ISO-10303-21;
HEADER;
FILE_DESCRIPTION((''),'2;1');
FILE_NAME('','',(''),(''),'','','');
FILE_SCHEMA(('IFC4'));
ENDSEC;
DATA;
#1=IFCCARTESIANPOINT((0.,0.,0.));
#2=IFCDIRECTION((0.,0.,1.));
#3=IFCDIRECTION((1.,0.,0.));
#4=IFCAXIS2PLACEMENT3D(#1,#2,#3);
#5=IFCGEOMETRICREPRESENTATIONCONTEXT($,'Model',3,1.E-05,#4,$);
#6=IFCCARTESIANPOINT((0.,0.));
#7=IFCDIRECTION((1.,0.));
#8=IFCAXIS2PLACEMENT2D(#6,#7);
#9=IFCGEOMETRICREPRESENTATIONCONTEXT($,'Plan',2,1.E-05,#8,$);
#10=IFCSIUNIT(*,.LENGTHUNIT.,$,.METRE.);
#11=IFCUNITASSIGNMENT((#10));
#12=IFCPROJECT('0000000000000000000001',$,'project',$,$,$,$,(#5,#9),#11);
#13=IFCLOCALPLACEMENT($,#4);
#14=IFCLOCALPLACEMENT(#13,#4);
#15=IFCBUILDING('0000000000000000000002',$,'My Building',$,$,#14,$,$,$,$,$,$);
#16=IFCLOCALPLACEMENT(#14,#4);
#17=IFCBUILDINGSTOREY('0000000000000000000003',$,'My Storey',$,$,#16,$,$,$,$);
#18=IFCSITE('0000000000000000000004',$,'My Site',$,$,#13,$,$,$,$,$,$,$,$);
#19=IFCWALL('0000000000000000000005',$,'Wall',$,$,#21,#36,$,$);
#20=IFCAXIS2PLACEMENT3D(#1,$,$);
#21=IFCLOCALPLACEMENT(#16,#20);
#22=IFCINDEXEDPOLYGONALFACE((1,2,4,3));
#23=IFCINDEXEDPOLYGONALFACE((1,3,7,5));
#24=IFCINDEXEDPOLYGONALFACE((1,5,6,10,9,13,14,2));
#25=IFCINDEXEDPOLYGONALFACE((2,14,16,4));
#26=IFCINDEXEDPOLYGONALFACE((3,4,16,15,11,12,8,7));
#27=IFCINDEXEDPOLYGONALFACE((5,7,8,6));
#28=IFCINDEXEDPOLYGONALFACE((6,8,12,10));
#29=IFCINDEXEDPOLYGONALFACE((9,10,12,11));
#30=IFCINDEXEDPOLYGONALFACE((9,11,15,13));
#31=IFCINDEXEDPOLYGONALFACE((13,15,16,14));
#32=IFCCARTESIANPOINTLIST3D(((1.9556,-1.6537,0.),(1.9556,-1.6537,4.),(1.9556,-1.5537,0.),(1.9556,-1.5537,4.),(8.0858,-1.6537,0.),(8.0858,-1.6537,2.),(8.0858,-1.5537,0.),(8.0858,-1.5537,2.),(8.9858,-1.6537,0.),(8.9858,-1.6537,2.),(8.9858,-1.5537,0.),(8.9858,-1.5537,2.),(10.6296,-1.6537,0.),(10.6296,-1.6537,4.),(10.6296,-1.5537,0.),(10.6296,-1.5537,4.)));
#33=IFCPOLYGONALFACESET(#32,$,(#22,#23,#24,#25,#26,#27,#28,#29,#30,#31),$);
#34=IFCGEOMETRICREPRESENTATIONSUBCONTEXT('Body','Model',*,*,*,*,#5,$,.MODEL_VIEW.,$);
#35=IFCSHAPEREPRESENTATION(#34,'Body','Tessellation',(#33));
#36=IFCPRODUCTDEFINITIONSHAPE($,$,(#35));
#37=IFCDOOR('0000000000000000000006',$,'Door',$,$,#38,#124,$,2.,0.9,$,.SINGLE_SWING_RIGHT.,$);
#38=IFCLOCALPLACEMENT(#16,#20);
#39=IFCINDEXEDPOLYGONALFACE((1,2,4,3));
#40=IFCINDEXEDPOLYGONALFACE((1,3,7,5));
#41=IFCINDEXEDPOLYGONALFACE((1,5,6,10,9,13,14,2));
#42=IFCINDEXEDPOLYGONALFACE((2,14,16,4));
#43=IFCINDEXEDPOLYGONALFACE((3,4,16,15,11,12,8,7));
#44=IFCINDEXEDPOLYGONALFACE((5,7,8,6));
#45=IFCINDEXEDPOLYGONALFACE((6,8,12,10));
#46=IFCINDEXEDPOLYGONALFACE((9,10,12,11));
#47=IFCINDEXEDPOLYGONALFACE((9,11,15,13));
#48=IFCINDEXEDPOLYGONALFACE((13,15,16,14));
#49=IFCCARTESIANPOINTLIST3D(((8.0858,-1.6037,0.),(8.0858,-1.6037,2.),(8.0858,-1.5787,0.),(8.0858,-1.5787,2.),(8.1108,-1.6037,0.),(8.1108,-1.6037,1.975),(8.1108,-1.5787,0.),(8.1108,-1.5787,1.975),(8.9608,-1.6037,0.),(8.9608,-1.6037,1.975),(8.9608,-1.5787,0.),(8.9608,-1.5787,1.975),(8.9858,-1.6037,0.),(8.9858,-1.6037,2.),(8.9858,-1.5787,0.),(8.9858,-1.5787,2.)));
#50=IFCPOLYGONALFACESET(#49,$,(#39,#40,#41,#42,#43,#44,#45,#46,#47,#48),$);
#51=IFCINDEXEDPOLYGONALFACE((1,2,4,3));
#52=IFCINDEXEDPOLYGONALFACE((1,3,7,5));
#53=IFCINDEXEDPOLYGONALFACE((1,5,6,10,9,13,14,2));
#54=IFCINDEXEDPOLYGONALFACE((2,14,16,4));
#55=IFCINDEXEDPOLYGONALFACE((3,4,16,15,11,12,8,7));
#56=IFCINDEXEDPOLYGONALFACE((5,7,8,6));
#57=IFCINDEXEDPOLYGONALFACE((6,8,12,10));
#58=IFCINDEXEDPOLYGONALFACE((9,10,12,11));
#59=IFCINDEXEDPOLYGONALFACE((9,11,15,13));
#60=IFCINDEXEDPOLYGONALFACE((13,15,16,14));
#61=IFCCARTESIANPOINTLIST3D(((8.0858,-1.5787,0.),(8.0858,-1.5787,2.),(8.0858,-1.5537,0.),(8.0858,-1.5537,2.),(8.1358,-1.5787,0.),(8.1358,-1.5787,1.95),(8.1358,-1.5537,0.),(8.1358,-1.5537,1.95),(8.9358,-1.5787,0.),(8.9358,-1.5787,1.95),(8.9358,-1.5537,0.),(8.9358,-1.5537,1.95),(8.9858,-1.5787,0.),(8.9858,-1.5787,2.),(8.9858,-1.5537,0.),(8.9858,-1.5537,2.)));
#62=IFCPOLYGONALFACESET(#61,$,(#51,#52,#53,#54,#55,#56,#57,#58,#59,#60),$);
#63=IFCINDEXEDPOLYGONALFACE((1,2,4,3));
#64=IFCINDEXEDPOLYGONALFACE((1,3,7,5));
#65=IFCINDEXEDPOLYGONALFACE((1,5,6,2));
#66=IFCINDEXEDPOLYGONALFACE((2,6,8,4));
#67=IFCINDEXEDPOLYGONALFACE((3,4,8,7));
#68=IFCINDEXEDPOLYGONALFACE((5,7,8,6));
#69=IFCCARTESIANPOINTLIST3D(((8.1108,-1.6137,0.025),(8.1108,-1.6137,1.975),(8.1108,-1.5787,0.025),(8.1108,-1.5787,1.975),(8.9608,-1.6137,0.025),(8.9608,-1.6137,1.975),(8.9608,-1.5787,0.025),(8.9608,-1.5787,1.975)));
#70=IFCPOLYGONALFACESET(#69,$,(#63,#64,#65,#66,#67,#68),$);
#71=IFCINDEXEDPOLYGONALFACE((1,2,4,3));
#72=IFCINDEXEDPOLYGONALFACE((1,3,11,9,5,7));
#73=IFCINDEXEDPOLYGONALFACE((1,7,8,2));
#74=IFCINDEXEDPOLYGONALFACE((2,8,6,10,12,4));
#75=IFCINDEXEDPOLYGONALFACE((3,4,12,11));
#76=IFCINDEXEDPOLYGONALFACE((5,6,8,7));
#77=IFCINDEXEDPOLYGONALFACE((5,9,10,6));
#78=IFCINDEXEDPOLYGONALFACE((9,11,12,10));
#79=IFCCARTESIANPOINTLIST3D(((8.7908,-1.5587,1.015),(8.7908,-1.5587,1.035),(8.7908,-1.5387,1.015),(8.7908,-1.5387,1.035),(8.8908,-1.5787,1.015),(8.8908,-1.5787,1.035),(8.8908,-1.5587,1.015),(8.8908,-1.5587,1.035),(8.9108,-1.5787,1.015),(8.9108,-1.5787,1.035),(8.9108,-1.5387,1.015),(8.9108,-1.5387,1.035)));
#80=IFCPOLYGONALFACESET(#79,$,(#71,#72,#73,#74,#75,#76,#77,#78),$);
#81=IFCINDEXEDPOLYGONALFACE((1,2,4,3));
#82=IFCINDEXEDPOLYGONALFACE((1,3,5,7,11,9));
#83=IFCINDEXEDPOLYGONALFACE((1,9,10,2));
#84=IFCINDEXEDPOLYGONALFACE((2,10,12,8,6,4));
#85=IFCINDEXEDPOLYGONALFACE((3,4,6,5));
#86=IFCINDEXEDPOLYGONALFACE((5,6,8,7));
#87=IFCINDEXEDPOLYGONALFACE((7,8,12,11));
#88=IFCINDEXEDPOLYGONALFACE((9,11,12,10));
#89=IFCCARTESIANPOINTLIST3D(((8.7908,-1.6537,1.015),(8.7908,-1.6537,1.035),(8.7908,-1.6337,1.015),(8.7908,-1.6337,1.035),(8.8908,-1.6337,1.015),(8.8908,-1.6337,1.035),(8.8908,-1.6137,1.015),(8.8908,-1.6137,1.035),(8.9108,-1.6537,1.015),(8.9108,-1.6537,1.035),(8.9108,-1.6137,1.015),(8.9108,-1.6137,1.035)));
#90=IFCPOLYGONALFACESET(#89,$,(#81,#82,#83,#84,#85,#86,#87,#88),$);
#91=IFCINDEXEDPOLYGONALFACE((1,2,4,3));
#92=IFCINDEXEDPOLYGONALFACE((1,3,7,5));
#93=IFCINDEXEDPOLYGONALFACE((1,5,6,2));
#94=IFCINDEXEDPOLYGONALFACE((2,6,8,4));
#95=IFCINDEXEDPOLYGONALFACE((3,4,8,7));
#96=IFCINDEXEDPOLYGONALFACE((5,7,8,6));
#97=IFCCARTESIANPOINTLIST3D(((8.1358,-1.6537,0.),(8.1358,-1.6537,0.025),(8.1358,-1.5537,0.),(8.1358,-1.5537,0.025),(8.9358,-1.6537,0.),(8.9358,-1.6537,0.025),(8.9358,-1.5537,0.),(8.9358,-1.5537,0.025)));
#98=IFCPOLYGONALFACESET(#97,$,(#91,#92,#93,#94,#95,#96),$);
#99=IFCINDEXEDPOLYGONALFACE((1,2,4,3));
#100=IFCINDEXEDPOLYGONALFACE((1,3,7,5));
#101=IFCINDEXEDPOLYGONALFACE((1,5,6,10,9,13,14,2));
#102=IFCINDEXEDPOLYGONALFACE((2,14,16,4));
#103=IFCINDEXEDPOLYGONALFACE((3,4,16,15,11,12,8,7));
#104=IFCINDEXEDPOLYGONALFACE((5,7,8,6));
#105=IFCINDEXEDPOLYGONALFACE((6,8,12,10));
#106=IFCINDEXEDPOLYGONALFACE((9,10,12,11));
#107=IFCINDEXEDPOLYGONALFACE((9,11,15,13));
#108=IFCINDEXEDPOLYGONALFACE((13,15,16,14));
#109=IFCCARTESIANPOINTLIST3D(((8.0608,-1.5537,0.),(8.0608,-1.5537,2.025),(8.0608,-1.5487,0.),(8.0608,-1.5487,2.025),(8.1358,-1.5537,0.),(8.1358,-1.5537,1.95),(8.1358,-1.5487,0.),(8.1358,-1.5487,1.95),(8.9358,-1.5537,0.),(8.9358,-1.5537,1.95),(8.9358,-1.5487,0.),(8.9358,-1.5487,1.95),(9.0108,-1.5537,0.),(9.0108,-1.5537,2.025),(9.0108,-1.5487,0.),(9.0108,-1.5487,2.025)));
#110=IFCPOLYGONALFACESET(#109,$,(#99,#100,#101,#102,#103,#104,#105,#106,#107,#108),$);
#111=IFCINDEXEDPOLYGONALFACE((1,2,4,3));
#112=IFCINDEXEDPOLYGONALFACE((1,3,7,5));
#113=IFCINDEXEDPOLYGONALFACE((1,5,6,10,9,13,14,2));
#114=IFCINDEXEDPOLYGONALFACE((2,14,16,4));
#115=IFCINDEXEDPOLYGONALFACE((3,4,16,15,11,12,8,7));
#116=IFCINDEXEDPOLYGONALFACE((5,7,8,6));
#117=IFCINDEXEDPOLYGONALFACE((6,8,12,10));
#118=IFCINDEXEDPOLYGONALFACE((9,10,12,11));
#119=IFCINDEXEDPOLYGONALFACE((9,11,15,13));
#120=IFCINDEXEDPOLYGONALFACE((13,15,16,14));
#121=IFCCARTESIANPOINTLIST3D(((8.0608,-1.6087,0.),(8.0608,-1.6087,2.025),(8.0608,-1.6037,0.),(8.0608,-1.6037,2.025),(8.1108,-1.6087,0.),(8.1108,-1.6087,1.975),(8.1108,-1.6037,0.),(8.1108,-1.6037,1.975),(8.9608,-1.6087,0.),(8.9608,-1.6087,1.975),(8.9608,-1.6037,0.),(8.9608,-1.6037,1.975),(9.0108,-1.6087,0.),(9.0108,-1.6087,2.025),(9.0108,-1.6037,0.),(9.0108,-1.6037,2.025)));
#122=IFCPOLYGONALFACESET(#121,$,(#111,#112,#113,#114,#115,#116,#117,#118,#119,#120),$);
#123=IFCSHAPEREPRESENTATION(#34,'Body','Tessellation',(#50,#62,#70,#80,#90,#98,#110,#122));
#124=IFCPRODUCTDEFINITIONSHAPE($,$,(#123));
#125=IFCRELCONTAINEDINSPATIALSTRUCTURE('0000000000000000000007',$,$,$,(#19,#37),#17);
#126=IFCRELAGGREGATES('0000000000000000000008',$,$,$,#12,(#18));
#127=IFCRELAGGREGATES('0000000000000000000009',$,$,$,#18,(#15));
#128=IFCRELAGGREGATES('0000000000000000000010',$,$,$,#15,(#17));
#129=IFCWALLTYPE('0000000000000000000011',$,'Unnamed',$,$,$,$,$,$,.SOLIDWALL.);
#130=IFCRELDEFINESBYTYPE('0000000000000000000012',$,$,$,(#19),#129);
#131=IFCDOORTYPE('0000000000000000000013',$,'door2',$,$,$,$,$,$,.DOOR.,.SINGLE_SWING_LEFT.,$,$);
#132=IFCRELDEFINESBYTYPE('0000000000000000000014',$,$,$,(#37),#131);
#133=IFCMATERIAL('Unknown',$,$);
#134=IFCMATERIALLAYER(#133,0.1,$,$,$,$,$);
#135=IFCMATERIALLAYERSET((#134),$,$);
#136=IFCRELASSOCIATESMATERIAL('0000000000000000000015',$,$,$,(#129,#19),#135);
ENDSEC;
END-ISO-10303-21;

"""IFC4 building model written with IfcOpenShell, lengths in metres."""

from ifc_helpers import new_model, entity, si_unit, frame, origin_with_axes, origin_2d_with_axis, place, context, subcontext, project, spatial, line, indexed_curve, outline, extrude, shape, source, transform, mapped, material, layer, layer_set, layer_usage, type_object, type_shapes, element, fill, save


model = new_model("IFC4")

# Units and contexts
model_context = context("Model", 3, precision=1e-05, world=origin_with_axes())
plan_context = context("Plan", 2, precision=1e-05, world=origin_2d_with_axis())
body_context_1 = subcontext(model_context, "Body", "Model", "MODEL_VIEW")
body_context_2 = subcontext(plan_context, "Body", "Plan", "PLAN_VIEW")
ifc_project = project(units=[si_unit("LENGTHUNIT", "METRE")], contexts=[model_context, plan_context])

# Site, building, storey
site_placement = place(None, origin_with_axes())
site = spatial("IfcSite", under=ifc_project, at=site_placement, Name="My Site")
building_placement = place(site_placement, origin_with_axes())
building = spatial("IfcBuilding", under=site, at=building_placement, Name="My Building")
storey_placement = place(building_placement, origin_with_axes())
storey = spatial("IfcBuildingStorey", under=building, at=storey_placement, Name="My Storey")

# Shared definitions
ifc_material = material(Name="Unknown")

# Shared definitions
ifc_layer_1 = layer(ifc_material, 0.1)
ifc_layer_set_1 = layer_set([ifc_layer_1])
wall_type = type_object("IfcWallType", Name="Unnamed", PredefinedType="SOLIDWALL", material=ifc_layer_set_1)

# Wall, opening, door
ifc_layer_usage_1 = layer_usage(ifc_layer_set_1, "AXIS2", "POSITIVE", 0.0)
wall_1_placement = place(storey_placement, frame((1.9556, -1.6537, 0.0), z_axis=(0.0, 0.0, 1.0), x_axis=(1.0, 0.0, 0.0)))
wall_1 = element("IfcWall", 1, at=wall_1_placement, inside=storey, type_object=wall_type, material=ifc_layer_usage_1, Name="Wall", context=body_context_1, shape_type="SweptSolid", body=[
    extrude(outline(indexed_curve([(0.0, 0.0), (0.0, 0.1), (8.674, 0.1), (8.674, 0.0)], segments=[line(1, 2, 3, 4, 1)])), origin_with_axes(), (0.0, 0.0, 1.0), 4.0),
])
shared_shape_1 = source(origin_with_axes(), body_context_1, "Body", "SweptSolid", [
    extrude(outline(indexed_curve([(0.0, 0.0), (0.9, 0.0), (0.9, 2.0), (0.0, 2.0)], segments=[line(1, 2, 3, 4, 1)])), frame((0.0, -0.6, 0.0), z_axis=(0.0, -1.0, 0.0), x_axis=(1.0, 0.0, 0.0)), (0.0, 0.0, -1.0), 1.2),
])
opening_placement = place(wall_1_placement, frame((7.0302, 0.1, 0.0), z_axis=(0.0, 0.0, 1.0), x_axis=(-1.0, 0.0, 0.0)))
opening = element("IfcOpeningElement", 2, at=opening_placement, cuts=wall_1, PredefinedType="OPENING", context=body_context_1, shape_type="MappedRepresentation", body=[
    mapped(shared_shape_1, transform((0.0, 0.0, 0.0), x_axis=(1.0, 0.0, 0.0), y_axis=(0.0, 1.0, 0.0), z_axis=(0.0, 0.0, 1.0), scale=1.0)),
])
door_type = type_object("IfcDoorType", Name="door2", OperationType="SINGLE_SWING_LEFT", PredefinedType="DOOR")
shared_shape_2 = source(origin_with_axes(), body_context_1, "Body", "SweptSolid", [
    extrude(outline(indexed_curve([(0.0, 0.0), (0.0, 2.0), (0.9, 2.0), (0.9, 0.0), (0.875, 0.0), (0.875, 1.975), (0.025, 1.975), (0.025, 0.0)], segments=[line(1, 2, 3, 4, 5, 6, 7, 8, 1)])), frame((0.0, 0.025, 0.0), z_axis=(0.0, -1.0, 0.0), x_axis=(1.0, 0.0, 0.0)), (0.0, 0.0, -1.0), 0.025),
    extrude(outline(indexed_curve([(0.0, 0.0), (0.0, 2.0), (0.9, 2.0), (0.9, 0.0), (0.85, 0.0), (0.85, 1.95), (0.05, 1.95), (0.05, 0.0)], segments=[line(1, 2, 3, 4, 5, 6, 7, 8, 1)])), frame((0.0, 0.0, 0.0), z_axis=(0.0, -1.0, 0.0), x_axis=(1.0, 0.0, 0.0)), (0.0, 0.0, -1.0), 0.025),
    extrude(outline(indexed_curve([(0.0, 0.0), (0.85, 0.0), (0.85, 0.035), (0.0, 0.035)], segments=[line(1, 2, 3, 4, 1)])), frame((0.025, 0.025, 0.025), z_axis=(0.0, 0.0, 1.0), x_axis=(1.0, 0.0, 0.0)), (0.0, 0.0, 1.0), 1.95),
    extrude(outline(indexed_curve([(0.0, 0.0), (0.0, -0.04), (0.12, -0.04), (0.12, -0.02), (0.02, -0.02), (0.02, 0.0)], segments=[line(1, 2, 3, 4, 5, 6, 1)])), frame((0.075, 0.025, 1.015), z_axis=(0.0, 0.0, 1.0), x_axis=(1.0, 0.0, 0.0)), (0.0, 0.0, 1.0), 0.02),
    extrude(outline(indexed_curve([(0.0, 0.0), (0.0, 0.04), (0.12, 0.04), (0.12, 0.02), (0.02, 0.02), (0.02, 0.0)], segments=[line(1, 2, 3, 4, 5, 6, 1)])), frame((0.075, 0.06, 1.015), z_axis=(0.0, 0.0, 1.0), x_axis=(1.0, 0.0, 0.0)), (0.0, 0.0, 1.0), 0.02),
    extrude(outline(indexed_curve([(0.0, 0.0), (0.8, 0.0), (0.8, 0.1), (0.0, 0.1)], segments=[line(1, 2, 3, 4, 1)])), frame((0.05, 0.0, 0.0), z_axis=(0.0, 0.0, 1.0), x_axis=(1.0, 0.0, 0.0)), (0.0, 0.0, 1.0), 0.025),
    extrude(outline(indexed_curve([(0.0, 0.0), (0.0, 2.025), (0.95, 2.025), (0.95, 0.0), (0.875, 0.0), (0.875, 1.95), (0.075, 1.95), (0.075, 0.0)], segments=[line(1, 2, 3, 4, 5, 6, 7, 8, 1)])), frame((-0.025, -0.005, 0.0), z_axis=(0.0, -1.0, 0.0), x_axis=(1.0, 0.0, 0.0)), (0.0, 0.0, -1.0), 0.005),
    extrude(outline(indexed_curve([(0.0, 0.0), (0.0, 2.025), (0.95, 2.025), (0.95, 0.0), (0.9, 0.0), (0.9, 1.975), (0.05, 1.975), (0.05, 0.0)], segments=[line(1, 2, 3, 4, 5, 6, 7, 8, 1)])), frame((-0.025, 0.05, 0.0), z_axis=(0.0, -1.0, 0.0), x_axis=(1.0, 0.0, 0.0)), (0.0, 0.0, -1.0), 0.005),
])
shared_shape_3 = source(origin_with_axes(), body_context_2, "Body", "Curve2D", [
    entity("IfcIndexedPolyCurve", entity("IfcCartesianPointList2D", [[0.0, 0.0], [0.0, 0.05], [0.025, 0.05], [0.025, 0.025], [0.05, 0.025], [0.05, 0.0]]), [entity("IfcLineIndex", [1, 2, 3, 4, 5, 6, 1])]),
    entity("IfcIndexedPolyCurve", entity("IfcCartesianPointList2D", [[0.9, 0.0], [0.9, 0.05], [0.875, 0.05], [0.875, 0.025], [0.85, 0.025], [0.85, 0.0]]), [entity("IfcLineIndex", [1, 2, 3, 4, 5, 6, 1])]),
    entity("IfcTrimmedCurve", entity("IfcEllipse", entity("IfcAxis2Placement2D", entity("IfcCartesianPoint", [0.84, 0.05]), entity("IfcDirection", [1.0, 0.0])), 0.815, 0.85), [entity("IfcCartesianPoint", [0.84, 0.9])], [entity("IfcCartesianPoint", [0.025, 0.05])], True, "CARTESIAN"),
    entity("IfcIndexedPolyCurve", entity("IfcCartesianPointList2D", [[0.875, 0.05], [0.84, 0.05], [0.84, 0.9], [0.875, 0.9]]), [entity("IfcLineIndex", [1, 2, 3, 4, 1])]),
])
type_shapes(door_type, [shared_shape_2, shared_shape_3])
door_placement = place(opening_placement, origin_with_axes())
door = element("IfcDoor", 3, at=door_placement, inside=storey, type_object=door_type, Name="Door", OperationType="SINGLE_SWING_RIGHT", OverallHeight=2.0, OverallWidth=0.9, shapes=[
    shape(body_context_1, "Body", "MappedRepresentation", [mapped(shared_shape_2, transform((0.0, 0.0, 0.0), x_axis=(1.0, 0.0, 0.0), y_axis=(0.0, 1.0, 0.0), z_axis=(0.0, 0.0, 1.0), scale=1.0))]),
    shape(body_context_2, "Body", "MappedRepresentation", [mapped(shared_shape_3, transform((0.0, 0.0, 0.0), x_axis=(1.0, 0.0, 0.0), y_axis=(0.0, 1.0, 0.0), z_axis=(0.0, 0.0, 1.0), scale=1.0))]),
])
fill(opening, door)

save(model, "model.ifc")
